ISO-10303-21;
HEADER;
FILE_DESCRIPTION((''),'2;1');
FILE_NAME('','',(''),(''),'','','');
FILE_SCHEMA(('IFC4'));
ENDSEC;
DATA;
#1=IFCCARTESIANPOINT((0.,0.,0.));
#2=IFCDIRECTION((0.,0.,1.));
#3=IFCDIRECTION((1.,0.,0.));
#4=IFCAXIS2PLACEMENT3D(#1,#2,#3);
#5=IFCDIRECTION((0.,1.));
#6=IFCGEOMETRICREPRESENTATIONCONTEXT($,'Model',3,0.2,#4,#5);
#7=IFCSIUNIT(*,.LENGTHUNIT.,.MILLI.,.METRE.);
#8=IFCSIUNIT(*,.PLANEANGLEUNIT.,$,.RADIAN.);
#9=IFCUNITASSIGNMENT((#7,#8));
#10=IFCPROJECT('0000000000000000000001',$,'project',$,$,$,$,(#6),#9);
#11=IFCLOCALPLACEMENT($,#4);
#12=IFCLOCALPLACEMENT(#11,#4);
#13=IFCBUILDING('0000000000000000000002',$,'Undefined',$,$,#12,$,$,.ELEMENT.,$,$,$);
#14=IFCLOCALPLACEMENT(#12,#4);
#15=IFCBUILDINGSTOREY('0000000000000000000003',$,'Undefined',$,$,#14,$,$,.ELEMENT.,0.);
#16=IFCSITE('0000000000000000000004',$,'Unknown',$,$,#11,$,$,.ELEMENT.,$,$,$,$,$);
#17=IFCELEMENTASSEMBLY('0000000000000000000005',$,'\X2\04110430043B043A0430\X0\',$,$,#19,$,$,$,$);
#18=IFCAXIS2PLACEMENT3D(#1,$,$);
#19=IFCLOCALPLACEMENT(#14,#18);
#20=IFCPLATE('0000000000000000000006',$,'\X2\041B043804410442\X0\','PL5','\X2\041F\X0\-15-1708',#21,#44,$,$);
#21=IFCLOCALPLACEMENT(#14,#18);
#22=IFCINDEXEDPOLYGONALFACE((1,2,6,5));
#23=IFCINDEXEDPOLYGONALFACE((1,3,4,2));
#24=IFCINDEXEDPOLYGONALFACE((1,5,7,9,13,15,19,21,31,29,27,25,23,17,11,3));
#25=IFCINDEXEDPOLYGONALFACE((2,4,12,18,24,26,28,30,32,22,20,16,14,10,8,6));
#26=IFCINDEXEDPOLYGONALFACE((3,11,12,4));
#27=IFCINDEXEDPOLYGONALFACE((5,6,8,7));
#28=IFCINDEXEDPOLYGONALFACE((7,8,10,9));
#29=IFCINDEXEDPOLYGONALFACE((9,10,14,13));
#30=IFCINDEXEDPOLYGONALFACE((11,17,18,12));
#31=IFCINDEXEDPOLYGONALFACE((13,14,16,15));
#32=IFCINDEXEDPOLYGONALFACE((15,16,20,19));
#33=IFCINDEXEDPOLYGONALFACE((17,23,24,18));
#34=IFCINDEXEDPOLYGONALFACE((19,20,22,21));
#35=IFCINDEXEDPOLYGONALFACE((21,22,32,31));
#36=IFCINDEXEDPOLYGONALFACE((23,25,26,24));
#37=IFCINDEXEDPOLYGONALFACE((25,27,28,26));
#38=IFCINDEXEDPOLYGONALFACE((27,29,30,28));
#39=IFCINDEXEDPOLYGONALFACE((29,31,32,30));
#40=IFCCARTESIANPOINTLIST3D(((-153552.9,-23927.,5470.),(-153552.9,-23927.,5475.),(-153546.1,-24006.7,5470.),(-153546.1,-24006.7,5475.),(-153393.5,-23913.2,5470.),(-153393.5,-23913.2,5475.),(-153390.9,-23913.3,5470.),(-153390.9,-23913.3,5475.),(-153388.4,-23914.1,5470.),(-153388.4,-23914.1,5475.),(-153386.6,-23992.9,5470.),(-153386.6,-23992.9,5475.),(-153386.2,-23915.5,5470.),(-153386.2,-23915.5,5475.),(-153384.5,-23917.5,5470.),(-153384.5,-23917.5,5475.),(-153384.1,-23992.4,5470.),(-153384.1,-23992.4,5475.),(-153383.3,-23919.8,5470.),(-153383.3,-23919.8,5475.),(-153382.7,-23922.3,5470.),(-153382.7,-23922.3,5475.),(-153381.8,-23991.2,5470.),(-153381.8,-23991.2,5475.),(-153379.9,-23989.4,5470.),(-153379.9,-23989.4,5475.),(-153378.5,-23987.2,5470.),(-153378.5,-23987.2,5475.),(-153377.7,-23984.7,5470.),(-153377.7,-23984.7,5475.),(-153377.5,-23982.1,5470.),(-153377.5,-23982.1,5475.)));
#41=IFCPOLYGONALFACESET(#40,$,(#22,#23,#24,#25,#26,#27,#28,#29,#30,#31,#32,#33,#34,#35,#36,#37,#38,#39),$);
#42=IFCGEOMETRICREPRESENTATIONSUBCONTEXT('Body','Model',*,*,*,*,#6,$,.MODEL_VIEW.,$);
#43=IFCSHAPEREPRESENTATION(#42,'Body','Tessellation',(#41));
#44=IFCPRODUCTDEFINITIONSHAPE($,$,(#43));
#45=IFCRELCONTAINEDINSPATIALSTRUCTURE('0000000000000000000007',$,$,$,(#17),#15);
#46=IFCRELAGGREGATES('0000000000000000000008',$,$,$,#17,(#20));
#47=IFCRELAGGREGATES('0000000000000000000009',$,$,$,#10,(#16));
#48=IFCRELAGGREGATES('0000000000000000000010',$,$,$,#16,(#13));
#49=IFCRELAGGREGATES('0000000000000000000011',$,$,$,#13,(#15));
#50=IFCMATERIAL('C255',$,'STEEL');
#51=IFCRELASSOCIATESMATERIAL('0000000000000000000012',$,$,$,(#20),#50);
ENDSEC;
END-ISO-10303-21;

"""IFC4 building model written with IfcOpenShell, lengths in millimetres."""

from ifc_helpers import new_model, si_unit, direction, frame, origin_with_axes, place, context, subcontext, project, spatial, line, arc, indexed_curve, outline, extrude, material, element, aggregate, save


model = new_model("IFC4")

# Units and contexts
model_context = context("Model", 3, precision=0.2, world=origin_with_axes(), true_north=direction((0.0, 1.0)))
body_context = subcontext(model_context, "Body", "Model", "MODEL_VIEW")
ifc_project = project(units=[si_unit("LENGTHUNIT", "METRE", prefix="MILLI"), si_unit("PLANEANGLEUNIT", "RADIAN")], contexts=[model_context])

# Site, building, storey
site_placement = place(None, origin_with_axes())
site = spatial("IfcSite", under=ifc_project, at=site_placement, Name="Unknown", CompositionType="ELEMENT")
building_placement = place(site_placement, origin_with_axes())
building = spatial("IfcBuilding", under=site, at=building_placement, Name="Undefined", CompositionType="ELEMENT")
storey_placement = place(building_placement, origin_with_axes())
storey = spatial("IfcBuildingStorey", under=building, at=storey_placement, Name="Undefined", CompositionType="ELEMENT", Elevation=0.0)

# Shared definitions
ifc_material_1 = material(Name="C255", Category="STEEL")

# Element assembly, plate
assembly_1_placement = place(storey_placement, frame((-153552.0, -23967.1, 5606.0), z_axis=(0.996285, 0.086114, 0.0), x_axis=(0.0, 0.0, -1.0)))
assembly_1 = element("IfcElementAssembly", 1, at=assembly_1_placement, inside=storey, Name="Балка")
plate_1_placement = place(assembly_1_placement, frame((133.5, 40.0, 2.5), z_axis=(-1.0, 0.0, 0.0), x_axis=(0.0, -1.0, 0.0)))
plate_1 = element("IfcPlate", 2, at=plate_1_placement, material=ifc_material_1, Name="Лист", Description="PL5", ObjectType="П-15-1708", context=body_context, shape_type="SolidModel", body=[
    extrude(outline(indexed_curve([(0.0, 0.0), (80.0, 0.0), (80.0, 160.0), (77.1, 167.1), (70.0, 170.0), (10.0, 170.0), (2.9, 167.1), (0.0, 160.0)], segments=[line(1, 2, 3), arc(3, 4, 5), line(5, 6), arc(6, 7, 8), line(8, 1)])), frame((0.0, 0.0, 2.5), z_axis=(0.0, 0.0, 1.0), x_axis=(1.0, 0.0, 0.0)), (0.0, 0.0, -1.0), 5.0),
])

aggregate(assembly_1, [plate_1])

save(model, "model.ifc")
